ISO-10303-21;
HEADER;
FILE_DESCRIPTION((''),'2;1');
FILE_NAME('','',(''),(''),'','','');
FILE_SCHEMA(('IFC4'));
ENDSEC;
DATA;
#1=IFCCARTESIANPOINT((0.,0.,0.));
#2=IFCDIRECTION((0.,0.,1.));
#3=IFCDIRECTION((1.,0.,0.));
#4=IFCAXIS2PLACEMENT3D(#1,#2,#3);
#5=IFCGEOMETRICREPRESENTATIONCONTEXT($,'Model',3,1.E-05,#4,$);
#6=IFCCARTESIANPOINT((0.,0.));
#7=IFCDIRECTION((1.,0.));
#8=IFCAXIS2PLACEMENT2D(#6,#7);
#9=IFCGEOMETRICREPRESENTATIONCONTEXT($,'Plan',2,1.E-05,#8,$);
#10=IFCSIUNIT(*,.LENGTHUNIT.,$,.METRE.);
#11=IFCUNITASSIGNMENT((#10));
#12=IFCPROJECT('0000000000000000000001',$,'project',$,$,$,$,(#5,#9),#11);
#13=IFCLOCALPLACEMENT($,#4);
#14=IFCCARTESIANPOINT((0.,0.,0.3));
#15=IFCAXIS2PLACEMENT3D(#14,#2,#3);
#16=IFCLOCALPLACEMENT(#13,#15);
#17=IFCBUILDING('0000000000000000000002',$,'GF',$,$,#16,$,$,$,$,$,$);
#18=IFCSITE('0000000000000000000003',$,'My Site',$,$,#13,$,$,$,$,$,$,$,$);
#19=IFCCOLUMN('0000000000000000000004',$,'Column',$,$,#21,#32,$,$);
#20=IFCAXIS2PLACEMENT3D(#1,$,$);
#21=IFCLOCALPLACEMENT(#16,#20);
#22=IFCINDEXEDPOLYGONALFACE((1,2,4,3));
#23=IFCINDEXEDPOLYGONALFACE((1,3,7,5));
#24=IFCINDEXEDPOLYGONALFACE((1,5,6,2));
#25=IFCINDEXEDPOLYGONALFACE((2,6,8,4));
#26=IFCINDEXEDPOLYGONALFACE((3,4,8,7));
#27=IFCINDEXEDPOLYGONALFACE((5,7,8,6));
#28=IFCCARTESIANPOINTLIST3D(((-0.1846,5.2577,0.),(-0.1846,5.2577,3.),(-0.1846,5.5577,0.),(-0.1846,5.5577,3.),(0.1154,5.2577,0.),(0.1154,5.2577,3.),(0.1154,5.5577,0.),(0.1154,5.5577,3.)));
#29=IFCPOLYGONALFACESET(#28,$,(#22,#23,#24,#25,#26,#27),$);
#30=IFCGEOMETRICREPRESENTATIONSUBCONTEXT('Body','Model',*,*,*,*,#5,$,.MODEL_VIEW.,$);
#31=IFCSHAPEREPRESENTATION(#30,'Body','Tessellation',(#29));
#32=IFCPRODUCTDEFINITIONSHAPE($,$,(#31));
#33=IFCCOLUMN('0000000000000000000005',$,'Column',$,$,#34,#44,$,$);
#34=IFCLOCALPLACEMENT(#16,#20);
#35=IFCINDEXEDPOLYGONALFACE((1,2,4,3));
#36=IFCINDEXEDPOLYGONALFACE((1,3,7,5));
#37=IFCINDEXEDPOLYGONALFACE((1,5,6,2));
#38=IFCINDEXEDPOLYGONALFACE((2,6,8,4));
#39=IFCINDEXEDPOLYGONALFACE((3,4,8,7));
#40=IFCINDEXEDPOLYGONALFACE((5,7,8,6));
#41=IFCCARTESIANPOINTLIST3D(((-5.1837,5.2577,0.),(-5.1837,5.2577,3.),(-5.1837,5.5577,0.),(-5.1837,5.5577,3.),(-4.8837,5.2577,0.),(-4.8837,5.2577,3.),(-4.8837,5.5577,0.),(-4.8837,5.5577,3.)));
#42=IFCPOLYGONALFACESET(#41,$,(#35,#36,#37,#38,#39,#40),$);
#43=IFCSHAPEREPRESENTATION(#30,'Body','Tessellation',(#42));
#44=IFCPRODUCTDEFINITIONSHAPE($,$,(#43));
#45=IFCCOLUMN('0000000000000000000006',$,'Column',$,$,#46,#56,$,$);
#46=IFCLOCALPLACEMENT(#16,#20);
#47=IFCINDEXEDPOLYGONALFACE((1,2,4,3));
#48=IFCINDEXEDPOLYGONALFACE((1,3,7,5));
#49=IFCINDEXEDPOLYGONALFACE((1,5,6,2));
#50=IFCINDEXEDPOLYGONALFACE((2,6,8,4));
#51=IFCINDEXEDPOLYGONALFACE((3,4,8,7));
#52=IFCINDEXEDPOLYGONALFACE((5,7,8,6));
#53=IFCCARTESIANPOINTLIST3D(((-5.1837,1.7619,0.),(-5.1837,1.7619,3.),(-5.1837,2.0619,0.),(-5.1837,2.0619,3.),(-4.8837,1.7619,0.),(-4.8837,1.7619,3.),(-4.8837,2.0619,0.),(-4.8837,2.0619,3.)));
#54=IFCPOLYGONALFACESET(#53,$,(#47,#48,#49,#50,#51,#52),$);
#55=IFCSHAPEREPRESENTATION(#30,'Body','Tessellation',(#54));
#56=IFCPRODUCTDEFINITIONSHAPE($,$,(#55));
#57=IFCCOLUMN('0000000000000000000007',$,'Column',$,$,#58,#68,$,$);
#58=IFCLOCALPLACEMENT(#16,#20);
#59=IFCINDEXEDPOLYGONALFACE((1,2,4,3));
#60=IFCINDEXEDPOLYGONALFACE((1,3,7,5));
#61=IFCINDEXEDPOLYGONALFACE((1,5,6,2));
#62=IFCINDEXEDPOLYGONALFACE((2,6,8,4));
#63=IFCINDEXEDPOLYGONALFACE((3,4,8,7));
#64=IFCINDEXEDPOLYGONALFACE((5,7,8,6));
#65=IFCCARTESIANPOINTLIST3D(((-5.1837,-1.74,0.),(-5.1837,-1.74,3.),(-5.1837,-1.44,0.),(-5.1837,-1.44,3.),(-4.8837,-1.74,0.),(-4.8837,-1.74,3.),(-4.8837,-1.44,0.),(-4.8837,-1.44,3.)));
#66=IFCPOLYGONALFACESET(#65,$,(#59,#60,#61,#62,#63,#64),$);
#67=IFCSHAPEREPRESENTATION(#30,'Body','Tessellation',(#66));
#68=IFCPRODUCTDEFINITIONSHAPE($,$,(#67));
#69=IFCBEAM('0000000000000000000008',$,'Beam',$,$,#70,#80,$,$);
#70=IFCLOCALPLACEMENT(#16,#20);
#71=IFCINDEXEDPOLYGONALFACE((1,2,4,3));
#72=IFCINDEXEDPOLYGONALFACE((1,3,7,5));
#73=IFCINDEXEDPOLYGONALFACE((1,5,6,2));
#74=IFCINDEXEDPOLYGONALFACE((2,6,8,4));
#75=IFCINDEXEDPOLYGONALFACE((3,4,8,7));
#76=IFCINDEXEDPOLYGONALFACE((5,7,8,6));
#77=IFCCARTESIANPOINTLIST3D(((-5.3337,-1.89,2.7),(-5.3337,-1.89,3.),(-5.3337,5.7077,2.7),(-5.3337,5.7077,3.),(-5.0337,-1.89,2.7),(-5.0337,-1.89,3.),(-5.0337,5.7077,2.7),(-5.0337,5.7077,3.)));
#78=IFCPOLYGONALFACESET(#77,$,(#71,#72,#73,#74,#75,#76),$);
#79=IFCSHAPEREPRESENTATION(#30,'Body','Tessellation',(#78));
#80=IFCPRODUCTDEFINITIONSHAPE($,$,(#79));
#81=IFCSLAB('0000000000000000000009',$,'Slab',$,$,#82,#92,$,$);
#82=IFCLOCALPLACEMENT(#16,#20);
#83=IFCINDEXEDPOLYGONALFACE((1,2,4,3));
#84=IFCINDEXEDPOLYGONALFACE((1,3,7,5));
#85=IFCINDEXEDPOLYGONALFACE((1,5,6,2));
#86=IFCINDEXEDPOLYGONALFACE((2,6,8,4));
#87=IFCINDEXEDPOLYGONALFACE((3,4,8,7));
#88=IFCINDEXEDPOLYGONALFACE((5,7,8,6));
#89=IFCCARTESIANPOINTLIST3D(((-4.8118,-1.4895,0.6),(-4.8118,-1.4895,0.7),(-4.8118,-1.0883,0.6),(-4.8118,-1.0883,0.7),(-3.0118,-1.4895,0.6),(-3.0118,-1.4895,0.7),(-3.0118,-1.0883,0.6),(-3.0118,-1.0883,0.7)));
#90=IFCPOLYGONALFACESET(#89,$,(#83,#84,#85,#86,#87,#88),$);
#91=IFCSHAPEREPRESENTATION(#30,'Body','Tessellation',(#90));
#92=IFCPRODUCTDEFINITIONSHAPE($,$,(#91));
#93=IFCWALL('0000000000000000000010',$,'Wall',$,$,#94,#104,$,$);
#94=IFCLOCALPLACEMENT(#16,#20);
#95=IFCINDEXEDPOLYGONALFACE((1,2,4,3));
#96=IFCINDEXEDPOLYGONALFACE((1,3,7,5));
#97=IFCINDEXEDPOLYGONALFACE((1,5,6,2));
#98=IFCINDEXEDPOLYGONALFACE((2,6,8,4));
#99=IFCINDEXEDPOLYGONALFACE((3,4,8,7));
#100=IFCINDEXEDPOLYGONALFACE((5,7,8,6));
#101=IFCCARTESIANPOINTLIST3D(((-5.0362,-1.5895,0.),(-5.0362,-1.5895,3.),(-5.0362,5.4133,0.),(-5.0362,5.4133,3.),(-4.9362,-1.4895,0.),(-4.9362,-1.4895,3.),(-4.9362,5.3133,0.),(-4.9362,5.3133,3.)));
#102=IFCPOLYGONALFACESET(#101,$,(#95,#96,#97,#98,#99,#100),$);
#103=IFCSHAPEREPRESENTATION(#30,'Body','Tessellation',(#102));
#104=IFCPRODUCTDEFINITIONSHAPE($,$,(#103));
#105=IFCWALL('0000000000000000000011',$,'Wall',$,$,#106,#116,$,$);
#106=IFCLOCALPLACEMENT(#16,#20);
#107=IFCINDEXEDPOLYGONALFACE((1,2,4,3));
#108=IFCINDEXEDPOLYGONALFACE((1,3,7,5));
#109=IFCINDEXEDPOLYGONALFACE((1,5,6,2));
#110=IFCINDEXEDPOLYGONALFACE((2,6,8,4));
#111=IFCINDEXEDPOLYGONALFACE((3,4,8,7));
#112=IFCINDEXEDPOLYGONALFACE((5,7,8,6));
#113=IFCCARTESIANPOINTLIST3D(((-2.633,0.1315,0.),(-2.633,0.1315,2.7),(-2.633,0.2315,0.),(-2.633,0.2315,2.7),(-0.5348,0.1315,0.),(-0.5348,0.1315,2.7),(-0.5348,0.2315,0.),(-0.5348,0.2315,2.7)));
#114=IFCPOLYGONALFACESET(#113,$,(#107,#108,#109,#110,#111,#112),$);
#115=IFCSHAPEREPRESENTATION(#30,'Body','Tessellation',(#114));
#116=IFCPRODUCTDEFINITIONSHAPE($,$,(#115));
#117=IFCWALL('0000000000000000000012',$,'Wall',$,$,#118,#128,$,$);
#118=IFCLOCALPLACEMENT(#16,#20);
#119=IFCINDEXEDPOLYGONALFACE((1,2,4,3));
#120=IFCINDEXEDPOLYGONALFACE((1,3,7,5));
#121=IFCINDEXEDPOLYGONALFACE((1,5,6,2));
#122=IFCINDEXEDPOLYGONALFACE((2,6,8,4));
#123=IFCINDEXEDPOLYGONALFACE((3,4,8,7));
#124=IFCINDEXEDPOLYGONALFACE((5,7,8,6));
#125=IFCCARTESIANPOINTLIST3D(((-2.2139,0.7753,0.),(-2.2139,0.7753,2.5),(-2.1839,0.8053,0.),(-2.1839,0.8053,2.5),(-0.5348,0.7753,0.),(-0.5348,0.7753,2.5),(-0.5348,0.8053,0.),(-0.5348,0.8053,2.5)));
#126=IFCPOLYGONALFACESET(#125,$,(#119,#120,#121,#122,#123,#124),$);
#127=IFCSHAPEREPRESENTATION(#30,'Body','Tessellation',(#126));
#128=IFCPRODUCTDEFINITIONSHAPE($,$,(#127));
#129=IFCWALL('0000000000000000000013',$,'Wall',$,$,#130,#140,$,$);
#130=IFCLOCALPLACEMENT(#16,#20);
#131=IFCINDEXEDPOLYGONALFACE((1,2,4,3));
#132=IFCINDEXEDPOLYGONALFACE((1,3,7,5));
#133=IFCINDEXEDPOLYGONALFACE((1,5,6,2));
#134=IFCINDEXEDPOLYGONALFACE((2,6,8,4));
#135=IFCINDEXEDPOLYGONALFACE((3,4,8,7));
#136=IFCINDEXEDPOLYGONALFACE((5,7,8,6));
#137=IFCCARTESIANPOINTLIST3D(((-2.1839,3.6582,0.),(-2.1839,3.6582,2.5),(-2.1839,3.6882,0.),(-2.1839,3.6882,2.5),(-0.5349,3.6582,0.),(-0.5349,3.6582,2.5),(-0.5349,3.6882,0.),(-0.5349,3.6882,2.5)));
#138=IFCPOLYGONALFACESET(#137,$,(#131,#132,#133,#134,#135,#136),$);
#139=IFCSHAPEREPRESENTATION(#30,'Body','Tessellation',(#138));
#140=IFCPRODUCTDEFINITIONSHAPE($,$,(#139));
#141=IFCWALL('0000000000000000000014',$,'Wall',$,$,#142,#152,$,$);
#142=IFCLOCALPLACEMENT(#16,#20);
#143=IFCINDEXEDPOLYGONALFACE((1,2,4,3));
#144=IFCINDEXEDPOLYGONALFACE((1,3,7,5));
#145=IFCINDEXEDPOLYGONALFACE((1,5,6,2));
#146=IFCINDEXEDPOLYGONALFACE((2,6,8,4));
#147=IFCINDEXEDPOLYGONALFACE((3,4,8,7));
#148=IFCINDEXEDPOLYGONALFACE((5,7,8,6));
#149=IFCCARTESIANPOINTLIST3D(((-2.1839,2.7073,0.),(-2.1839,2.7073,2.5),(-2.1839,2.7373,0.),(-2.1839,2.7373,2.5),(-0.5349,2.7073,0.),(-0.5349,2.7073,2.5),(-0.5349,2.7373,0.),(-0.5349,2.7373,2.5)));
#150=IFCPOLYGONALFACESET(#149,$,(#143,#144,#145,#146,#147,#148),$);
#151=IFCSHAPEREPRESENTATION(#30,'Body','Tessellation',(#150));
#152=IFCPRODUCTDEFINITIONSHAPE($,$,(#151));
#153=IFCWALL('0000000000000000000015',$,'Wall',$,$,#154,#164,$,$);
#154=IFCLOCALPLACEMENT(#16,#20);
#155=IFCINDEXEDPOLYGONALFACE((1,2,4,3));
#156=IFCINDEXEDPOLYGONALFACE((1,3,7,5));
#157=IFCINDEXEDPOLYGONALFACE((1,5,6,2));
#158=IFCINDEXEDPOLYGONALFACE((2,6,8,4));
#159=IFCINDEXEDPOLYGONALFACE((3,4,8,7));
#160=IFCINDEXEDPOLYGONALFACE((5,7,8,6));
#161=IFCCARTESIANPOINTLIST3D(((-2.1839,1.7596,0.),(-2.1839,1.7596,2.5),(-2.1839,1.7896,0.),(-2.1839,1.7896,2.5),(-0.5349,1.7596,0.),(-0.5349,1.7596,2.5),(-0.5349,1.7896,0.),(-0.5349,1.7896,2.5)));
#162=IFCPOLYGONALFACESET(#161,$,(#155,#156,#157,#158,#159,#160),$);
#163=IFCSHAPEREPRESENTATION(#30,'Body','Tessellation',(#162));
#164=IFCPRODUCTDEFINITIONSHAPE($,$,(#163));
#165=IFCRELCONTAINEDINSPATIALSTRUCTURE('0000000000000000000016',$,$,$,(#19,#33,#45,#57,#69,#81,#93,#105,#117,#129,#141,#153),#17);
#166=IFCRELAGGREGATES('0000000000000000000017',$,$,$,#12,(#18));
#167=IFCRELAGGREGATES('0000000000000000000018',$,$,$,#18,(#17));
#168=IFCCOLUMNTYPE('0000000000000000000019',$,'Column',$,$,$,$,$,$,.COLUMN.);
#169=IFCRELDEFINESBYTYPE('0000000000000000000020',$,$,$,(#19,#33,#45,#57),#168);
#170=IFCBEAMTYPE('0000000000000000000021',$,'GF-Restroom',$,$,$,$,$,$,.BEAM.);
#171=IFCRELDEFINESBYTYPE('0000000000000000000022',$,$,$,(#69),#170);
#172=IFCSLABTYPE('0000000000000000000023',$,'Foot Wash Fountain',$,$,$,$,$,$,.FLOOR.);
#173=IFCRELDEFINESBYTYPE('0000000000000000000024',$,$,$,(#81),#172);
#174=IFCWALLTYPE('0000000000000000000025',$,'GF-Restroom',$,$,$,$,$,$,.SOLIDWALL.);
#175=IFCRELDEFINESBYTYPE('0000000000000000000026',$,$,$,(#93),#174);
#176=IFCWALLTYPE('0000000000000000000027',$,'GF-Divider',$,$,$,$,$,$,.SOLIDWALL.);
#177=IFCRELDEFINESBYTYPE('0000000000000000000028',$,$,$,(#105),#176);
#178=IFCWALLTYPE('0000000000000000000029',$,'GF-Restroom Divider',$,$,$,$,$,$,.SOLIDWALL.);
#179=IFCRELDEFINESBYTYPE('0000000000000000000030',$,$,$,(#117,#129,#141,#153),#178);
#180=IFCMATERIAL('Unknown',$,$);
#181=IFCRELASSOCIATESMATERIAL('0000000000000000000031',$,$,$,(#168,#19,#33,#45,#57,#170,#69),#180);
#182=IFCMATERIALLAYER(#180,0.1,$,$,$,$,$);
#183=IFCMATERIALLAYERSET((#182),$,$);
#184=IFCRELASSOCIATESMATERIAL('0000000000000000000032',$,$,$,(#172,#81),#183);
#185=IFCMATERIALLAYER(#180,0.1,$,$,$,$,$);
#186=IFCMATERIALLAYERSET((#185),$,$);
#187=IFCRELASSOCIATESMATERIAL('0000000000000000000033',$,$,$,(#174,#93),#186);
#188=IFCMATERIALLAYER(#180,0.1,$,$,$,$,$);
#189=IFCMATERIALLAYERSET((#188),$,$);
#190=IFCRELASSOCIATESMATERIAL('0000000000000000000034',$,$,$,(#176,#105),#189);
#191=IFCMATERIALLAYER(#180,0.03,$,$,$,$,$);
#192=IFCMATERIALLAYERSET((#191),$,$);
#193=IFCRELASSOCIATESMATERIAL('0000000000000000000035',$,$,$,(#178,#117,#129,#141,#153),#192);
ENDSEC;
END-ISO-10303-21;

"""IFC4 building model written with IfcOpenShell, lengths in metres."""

from ifc_helpers import new_model, si_unit, frame, origin_with_axes, origin_2d_with_axis, place, context, subcontext, project, spatial, line, indexed_curve, rectangle, outline, extrude, material, layer, layer_set, layer_usage, material_profile, profile_set, profile_usage, type_object, element, save


model = new_model("IFC4")

# Units and contexts
model_context = context("Model", 3, precision=1e-05, world=origin_with_axes())
plan_context = context("Plan", 2, precision=1e-05, world=origin_2d_with_axis())
body_context_1 = subcontext(model_context, "Body", "Model", "MODEL_VIEW")
ifc_project = project(units=[si_unit("LENGTHUNIT", "METRE")], contexts=[model_context, plan_context])

# Site, building
site_placement = place(None, origin_with_axes())
site = spatial("IfcSite", under=ifc_project, at=site_placement, Name="My Site")
building_placement = place(site_placement, frame((0.0, 0.0, 0.3), z_axis=(0.0, 0.0, 1.0), x_axis=(1.0, 0.0, 0.0)))
building = spatial("IfcBuilding", under=site, at=building_placement, Name="GF")

# Columns
ifc_material = material(Name="Unknown")
ifc_material_profile_1 = material_profile(ifc_material, rectangle(XDim=0.3, YDim=0.3))
ifc_profile_set_1 = profile_set([ifc_material_profile_1])
ifc_profile_usage_1 = profile_usage(ifc_profile_set_1, cardinal=5)
column_type = type_object("IfcColumnType", Name="Column", PredefinedType="COLUMN", material=ifc_profile_set_1)
column_1_placement = place(building_placement, frame((-0.0346, 5.4077, 0.0), z_axis=(0.0, 0.0, 1.0), x_axis=(1.0, 0.0, 0.0)))
element("IfcColumn", 1, at=column_1_placement, inside=building, type_object=column_type, material=ifc_profile_usage_1, Name="Column", context=body_context_1, shape_type="SweptSolid", body=[
    extrude(rectangle(XDim=0.3, YDim=0.3), origin_with_axes(), (0.0, 0.0, 1.0), 3.0),
])
ifc_profile_usage_2 = profile_usage(ifc_profile_set_1, cardinal=5)
column_2_placement = place(building_placement, frame((-5.0337, 5.4077, 0.0), z_axis=(0.0, 0.0, 1.0), x_axis=(1.0, 0.0, 0.0)))
element("IfcColumn", 2, at=column_2_placement, inside=building, type_object=column_type, material=ifc_profile_usage_2, Name="Column", context=body_context_1, shape_type="SweptSolid", body=[
    extrude(rectangle(XDim=0.3, YDim=0.3), origin_with_axes(), (0.0, 0.0, 1.0), 3.0),
])
ifc_profile_usage_3 = profile_usage(ifc_profile_set_1, cardinal=5)
column_3_placement = place(building_placement, frame((-5.0337, 1.9119, 0.0), z_axis=(0.0, 0.0, 1.0), x_axis=(1.0, 0.0, 0.0)))
element("IfcColumn", 3, at=column_3_placement, inside=building, type_object=column_type, material=ifc_profile_usage_3, Name="Column", context=body_context_1, shape_type="SweptSolid", body=[
    extrude(rectangle(XDim=0.3, YDim=0.3), origin_with_axes(), (0.0, 0.0, 1.0), 3.0),
])
ifc_profile_usage_4 = profile_usage(ifc_profile_set_1, cardinal=5)
column_4_placement = place(building_placement, frame((-5.0337, -1.59, 0.0), z_axis=(0.0, 0.0, 1.0), x_axis=(1.0, 0.0, 0.0)))
element("IfcColumn", 4, at=column_4_placement, inside=building, type_object=column_type, material=ifc_profile_usage_4, Name="Column", context=body_context_1, shape_type="SweptSolid", body=[
    extrude(rectangle(XDim=0.3, YDim=0.3), origin_with_axes(), (0.0, 0.0, 1.0), 3.0),
])

# Beam
ifc_material_profile_2 = material_profile(ifc_material, rectangle(XDim=0.3, YDim=0.3))
ifc_profile_set_2 = profile_set([ifc_material_profile_2])
ifc_profile_usage_5 = profile_usage(ifc_profile_set_2, cardinal=8)
beam_type = type_object("IfcBeamType", Name="GF-Restroom", PredefinedType="BEAM", material=ifc_profile_set_2)
beam_placement = place(building_placement, frame((-5.1837, -1.89, 3.0), z_axis=(0.0, 1.0, 0.0), x_axis=(-1.0, 0.0, 0.0)))
element("IfcBeam", 5, at=beam_placement, inside=building, type_object=beam_type, material=ifc_profile_usage_5, Name="Beam", context=body_context_1, shape_type="SweptSolid", body=[
    extrude(rectangle(XDim=0.3, YDim=0.3), frame((0.0, -0.15, 0.0), z_axis=(0.0, 0.0, 1.0), x_axis=(1.0, 0.0, 0.0)), (0.0, 0.0, 1.0), 7.5977),
])

# Slab
ifc_layer_1 = layer(ifc_material, 0.1)
ifc_layer_set_1 = layer_set([ifc_layer_1])
slab_type_1 = type_object("IfcSlabType", Name="Foot Wash Fountain", PredefinedType="FLOOR", material=ifc_layer_set_1)
ifc_layer_usage_1 = layer_usage(ifc_layer_set_1, "AXIS3", "POSITIVE", -0.3)
slab_1_placement = place(building_placement, frame((-4.8118, -1.4895, 0.9), z_axis=(0.0, 0.0, 1.0), x_axis=(1.0, 0.0, 0.0)))
element("IfcSlab", 6, at=slab_1_placement, inside=building, type_object=slab_type_1, material=ifc_layer_usage_1, Name="Slab", context=body_context_1, shape_type="SweptSolid", body=[
    extrude(outline(indexed_curve([(0.0, 0.0), (0.0, 0.4011), (1.8, 0.4011), (1.8, 0.0), (0.0, 0.0)])), frame((0.0, 0.0, -0.3), z_axis=(0.0, 0.0, 1.0), x_axis=(1.0, 0.0, 0.0)), (0.0, 0.0, 1.0), 0.1),
])

# Wall
ifc_layer_2 = layer(ifc_material, 0.1)
ifc_layer_set_2 = layer_set([ifc_layer_2])
ifc_layer_usage_2 = layer_usage(ifc_layer_set_2, "AXIS2", "POSITIVE", 0.0)
wall_type_1 = type_object("IfcWallType", Name="GF-Restroom", PredefinedType="SOLIDWALL", material=ifc_layer_set_2)
wall_1_placement = place(building_placement, frame((-5.0362, 5.4133, 0.0), z_axis=(0.0, 0.0, 1.0), x_axis=(0.0, -1.0, 0.0)))
element("IfcWall", 7, at=wall_1_placement, inside=building, type_object=wall_type_1, material=ifc_layer_usage_2, Name="Wall", context=body_context_1, shape_type="SweptSolid", body=[
    extrude(outline(indexed_curve([(0.0, 0.0), (0.1, 0.1), (6.9028, 0.1), (7.0028, 0.0)], segments=[line(1, 2, 3, 4, 1)])), origin_with_axes(), (0.0, 0.0, 1.0), 3.0),
])

# Wall
ifc_layer_3 = layer(ifc_material, 0.1)
ifc_layer_set_3 = layer_set([ifc_layer_3])
ifc_layer_usage_3 = layer_usage(ifc_layer_set_3, "AXIS2", "POSITIVE", 0.0)
wall_type_2 = type_object("IfcWallType", Name="GF-Divider", PredefinedType="SOLIDWALL", material=ifc_layer_set_3)
wall_2_placement = place(building_placement, frame((-2.633, 0.1315, 0.0), z_axis=(0.0, 0.0, 1.0), x_axis=(1.0, 0.0, 0.0)))
element("IfcWall", 8, at=wall_2_placement, inside=building, type_object=wall_type_2, material=ifc_layer_usage_3, Name="Wall", context=body_context_1, shape_type="SweptSolid", body=[
    extrude(outline(indexed_curve([(0.0, 0.0), (0.0, 0.1), (2.0981, 0.1), (2.0981, 0.0)], segments=[line(1, 2, 3, 4, 1)])), origin_with_axes(), (0.0, 0.0, 1.0), 2.7),
])

# Shared definitions
ifc_layer_4 = layer(ifc_material, 0.03)
ifc_layer_set_4 = layer_set([ifc_layer_4])
wall_type_3 = type_object("IfcWallType", Name="GF-Restroom Divider", PredefinedType="SOLIDWALL", material=ifc_layer_set_4)

# Walls
ifc_layer_usage_4 = layer_usage(ifc_layer_set_4, "AXIS2", "POSITIVE", 0.0)
wall_3_placement = place(building_placement, frame((-0.5348, 0.8053, 0.0), z_axis=(0.0, 0.0, 1.0), x_axis=(-1.0, 0.0, 0.0)))
element("IfcWall", 9, at=wall_3_placement, inside=building, type_object=wall_type_3, material=ifc_layer_usage_4, Name="Wall", context=body_context_1, shape_type="SweptSolid", body=[
    extrude(outline(indexed_curve([(0.0, 0.0), (0.0, 0.03), (1.6791, 0.03), (1.6491, 0.0)], segments=[line(1, 2, 3, 4, 1)])), origin_with_axes(), (0.0, 0.0, 1.0), 2.5),
])
ifc_layer_usage_5 = layer_usage(ifc_layer_set_4, "AXIS2", "POSITIVE", 0.0)
wall_4_placement = place(building_placement, frame((-2.1839, 3.6582, 0.0), z_axis=(0.0, 0.0, 1.0), x_axis=(1.0, 0.0, 0.0)))
element("IfcWall", 10, at=wall_4_placement, inside=building, type_object=wall_type_3, material=ifc_layer_usage_5, Name="Wall", context=body_context_1, shape_type="SweptSolid", body=[
    extrude(outline(indexed_curve([(0.0, 0.0), (0.0, 0.03), (1.649, 0.03), (1.649, 0.0)], segments=[line(1, 2, 3, 4, 1)])), origin_with_axes(), (0.0, 0.0, 1.0), 2.5),
])
ifc_layer_usage_6 = layer_usage(ifc_layer_set_4, "AXIS2", "POSITIVE", 0.0)
wall_5_placement = place(building_placement, frame((-2.1839, 2.7073, 0.0), z_axis=(0.0, 0.0, 1.0), x_axis=(1.0, 0.0, 0.0)))
element("IfcWall", 11, at=wall_5_placement, inside=building, type_object=wall_type_3, material=ifc_layer_usage_6, Name="Wall", context=body_context_1, shape_type="SweptSolid", body=[
    extrude(outline(indexed_curve([(0.0, 0.0), (0.0, 0.03), (1.649, 0.03), (1.649, 0.0)], segments=[line(1, 2, 3, 4, 1)])), origin_with_axes(), (0.0, 0.0, 1.0), 2.5),
])
ifc_layer_usage_7 = layer_usage(ifc_layer_set_4, "AXIS2", "POSITIVE", 0.0)
wall_6_placement = place(building_placement, frame((-2.1839, 1.7596, 0.0), z_axis=(0.0, 0.0, 1.0), x_axis=(1.0, 0.0, 0.0)))
element("IfcWall", 12, at=wall_6_placement, inside=building, type_object=wall_type_3, material=ifc_layer_usage_7, Name="Wall", context=body_context_1, shape_type="SweptSolid", body=[
    extrude(outline(indexed_curve([(0.0, 0.0), (0.0, 0.03), (1.649, 0.03), (1.649, 0.0)], segments=[line(1, 2, 3, 4, 1)])), origin_with_axes(), (0.0, 0.0, 1.0), 2.5),
])

save(model, "model.ifc")
